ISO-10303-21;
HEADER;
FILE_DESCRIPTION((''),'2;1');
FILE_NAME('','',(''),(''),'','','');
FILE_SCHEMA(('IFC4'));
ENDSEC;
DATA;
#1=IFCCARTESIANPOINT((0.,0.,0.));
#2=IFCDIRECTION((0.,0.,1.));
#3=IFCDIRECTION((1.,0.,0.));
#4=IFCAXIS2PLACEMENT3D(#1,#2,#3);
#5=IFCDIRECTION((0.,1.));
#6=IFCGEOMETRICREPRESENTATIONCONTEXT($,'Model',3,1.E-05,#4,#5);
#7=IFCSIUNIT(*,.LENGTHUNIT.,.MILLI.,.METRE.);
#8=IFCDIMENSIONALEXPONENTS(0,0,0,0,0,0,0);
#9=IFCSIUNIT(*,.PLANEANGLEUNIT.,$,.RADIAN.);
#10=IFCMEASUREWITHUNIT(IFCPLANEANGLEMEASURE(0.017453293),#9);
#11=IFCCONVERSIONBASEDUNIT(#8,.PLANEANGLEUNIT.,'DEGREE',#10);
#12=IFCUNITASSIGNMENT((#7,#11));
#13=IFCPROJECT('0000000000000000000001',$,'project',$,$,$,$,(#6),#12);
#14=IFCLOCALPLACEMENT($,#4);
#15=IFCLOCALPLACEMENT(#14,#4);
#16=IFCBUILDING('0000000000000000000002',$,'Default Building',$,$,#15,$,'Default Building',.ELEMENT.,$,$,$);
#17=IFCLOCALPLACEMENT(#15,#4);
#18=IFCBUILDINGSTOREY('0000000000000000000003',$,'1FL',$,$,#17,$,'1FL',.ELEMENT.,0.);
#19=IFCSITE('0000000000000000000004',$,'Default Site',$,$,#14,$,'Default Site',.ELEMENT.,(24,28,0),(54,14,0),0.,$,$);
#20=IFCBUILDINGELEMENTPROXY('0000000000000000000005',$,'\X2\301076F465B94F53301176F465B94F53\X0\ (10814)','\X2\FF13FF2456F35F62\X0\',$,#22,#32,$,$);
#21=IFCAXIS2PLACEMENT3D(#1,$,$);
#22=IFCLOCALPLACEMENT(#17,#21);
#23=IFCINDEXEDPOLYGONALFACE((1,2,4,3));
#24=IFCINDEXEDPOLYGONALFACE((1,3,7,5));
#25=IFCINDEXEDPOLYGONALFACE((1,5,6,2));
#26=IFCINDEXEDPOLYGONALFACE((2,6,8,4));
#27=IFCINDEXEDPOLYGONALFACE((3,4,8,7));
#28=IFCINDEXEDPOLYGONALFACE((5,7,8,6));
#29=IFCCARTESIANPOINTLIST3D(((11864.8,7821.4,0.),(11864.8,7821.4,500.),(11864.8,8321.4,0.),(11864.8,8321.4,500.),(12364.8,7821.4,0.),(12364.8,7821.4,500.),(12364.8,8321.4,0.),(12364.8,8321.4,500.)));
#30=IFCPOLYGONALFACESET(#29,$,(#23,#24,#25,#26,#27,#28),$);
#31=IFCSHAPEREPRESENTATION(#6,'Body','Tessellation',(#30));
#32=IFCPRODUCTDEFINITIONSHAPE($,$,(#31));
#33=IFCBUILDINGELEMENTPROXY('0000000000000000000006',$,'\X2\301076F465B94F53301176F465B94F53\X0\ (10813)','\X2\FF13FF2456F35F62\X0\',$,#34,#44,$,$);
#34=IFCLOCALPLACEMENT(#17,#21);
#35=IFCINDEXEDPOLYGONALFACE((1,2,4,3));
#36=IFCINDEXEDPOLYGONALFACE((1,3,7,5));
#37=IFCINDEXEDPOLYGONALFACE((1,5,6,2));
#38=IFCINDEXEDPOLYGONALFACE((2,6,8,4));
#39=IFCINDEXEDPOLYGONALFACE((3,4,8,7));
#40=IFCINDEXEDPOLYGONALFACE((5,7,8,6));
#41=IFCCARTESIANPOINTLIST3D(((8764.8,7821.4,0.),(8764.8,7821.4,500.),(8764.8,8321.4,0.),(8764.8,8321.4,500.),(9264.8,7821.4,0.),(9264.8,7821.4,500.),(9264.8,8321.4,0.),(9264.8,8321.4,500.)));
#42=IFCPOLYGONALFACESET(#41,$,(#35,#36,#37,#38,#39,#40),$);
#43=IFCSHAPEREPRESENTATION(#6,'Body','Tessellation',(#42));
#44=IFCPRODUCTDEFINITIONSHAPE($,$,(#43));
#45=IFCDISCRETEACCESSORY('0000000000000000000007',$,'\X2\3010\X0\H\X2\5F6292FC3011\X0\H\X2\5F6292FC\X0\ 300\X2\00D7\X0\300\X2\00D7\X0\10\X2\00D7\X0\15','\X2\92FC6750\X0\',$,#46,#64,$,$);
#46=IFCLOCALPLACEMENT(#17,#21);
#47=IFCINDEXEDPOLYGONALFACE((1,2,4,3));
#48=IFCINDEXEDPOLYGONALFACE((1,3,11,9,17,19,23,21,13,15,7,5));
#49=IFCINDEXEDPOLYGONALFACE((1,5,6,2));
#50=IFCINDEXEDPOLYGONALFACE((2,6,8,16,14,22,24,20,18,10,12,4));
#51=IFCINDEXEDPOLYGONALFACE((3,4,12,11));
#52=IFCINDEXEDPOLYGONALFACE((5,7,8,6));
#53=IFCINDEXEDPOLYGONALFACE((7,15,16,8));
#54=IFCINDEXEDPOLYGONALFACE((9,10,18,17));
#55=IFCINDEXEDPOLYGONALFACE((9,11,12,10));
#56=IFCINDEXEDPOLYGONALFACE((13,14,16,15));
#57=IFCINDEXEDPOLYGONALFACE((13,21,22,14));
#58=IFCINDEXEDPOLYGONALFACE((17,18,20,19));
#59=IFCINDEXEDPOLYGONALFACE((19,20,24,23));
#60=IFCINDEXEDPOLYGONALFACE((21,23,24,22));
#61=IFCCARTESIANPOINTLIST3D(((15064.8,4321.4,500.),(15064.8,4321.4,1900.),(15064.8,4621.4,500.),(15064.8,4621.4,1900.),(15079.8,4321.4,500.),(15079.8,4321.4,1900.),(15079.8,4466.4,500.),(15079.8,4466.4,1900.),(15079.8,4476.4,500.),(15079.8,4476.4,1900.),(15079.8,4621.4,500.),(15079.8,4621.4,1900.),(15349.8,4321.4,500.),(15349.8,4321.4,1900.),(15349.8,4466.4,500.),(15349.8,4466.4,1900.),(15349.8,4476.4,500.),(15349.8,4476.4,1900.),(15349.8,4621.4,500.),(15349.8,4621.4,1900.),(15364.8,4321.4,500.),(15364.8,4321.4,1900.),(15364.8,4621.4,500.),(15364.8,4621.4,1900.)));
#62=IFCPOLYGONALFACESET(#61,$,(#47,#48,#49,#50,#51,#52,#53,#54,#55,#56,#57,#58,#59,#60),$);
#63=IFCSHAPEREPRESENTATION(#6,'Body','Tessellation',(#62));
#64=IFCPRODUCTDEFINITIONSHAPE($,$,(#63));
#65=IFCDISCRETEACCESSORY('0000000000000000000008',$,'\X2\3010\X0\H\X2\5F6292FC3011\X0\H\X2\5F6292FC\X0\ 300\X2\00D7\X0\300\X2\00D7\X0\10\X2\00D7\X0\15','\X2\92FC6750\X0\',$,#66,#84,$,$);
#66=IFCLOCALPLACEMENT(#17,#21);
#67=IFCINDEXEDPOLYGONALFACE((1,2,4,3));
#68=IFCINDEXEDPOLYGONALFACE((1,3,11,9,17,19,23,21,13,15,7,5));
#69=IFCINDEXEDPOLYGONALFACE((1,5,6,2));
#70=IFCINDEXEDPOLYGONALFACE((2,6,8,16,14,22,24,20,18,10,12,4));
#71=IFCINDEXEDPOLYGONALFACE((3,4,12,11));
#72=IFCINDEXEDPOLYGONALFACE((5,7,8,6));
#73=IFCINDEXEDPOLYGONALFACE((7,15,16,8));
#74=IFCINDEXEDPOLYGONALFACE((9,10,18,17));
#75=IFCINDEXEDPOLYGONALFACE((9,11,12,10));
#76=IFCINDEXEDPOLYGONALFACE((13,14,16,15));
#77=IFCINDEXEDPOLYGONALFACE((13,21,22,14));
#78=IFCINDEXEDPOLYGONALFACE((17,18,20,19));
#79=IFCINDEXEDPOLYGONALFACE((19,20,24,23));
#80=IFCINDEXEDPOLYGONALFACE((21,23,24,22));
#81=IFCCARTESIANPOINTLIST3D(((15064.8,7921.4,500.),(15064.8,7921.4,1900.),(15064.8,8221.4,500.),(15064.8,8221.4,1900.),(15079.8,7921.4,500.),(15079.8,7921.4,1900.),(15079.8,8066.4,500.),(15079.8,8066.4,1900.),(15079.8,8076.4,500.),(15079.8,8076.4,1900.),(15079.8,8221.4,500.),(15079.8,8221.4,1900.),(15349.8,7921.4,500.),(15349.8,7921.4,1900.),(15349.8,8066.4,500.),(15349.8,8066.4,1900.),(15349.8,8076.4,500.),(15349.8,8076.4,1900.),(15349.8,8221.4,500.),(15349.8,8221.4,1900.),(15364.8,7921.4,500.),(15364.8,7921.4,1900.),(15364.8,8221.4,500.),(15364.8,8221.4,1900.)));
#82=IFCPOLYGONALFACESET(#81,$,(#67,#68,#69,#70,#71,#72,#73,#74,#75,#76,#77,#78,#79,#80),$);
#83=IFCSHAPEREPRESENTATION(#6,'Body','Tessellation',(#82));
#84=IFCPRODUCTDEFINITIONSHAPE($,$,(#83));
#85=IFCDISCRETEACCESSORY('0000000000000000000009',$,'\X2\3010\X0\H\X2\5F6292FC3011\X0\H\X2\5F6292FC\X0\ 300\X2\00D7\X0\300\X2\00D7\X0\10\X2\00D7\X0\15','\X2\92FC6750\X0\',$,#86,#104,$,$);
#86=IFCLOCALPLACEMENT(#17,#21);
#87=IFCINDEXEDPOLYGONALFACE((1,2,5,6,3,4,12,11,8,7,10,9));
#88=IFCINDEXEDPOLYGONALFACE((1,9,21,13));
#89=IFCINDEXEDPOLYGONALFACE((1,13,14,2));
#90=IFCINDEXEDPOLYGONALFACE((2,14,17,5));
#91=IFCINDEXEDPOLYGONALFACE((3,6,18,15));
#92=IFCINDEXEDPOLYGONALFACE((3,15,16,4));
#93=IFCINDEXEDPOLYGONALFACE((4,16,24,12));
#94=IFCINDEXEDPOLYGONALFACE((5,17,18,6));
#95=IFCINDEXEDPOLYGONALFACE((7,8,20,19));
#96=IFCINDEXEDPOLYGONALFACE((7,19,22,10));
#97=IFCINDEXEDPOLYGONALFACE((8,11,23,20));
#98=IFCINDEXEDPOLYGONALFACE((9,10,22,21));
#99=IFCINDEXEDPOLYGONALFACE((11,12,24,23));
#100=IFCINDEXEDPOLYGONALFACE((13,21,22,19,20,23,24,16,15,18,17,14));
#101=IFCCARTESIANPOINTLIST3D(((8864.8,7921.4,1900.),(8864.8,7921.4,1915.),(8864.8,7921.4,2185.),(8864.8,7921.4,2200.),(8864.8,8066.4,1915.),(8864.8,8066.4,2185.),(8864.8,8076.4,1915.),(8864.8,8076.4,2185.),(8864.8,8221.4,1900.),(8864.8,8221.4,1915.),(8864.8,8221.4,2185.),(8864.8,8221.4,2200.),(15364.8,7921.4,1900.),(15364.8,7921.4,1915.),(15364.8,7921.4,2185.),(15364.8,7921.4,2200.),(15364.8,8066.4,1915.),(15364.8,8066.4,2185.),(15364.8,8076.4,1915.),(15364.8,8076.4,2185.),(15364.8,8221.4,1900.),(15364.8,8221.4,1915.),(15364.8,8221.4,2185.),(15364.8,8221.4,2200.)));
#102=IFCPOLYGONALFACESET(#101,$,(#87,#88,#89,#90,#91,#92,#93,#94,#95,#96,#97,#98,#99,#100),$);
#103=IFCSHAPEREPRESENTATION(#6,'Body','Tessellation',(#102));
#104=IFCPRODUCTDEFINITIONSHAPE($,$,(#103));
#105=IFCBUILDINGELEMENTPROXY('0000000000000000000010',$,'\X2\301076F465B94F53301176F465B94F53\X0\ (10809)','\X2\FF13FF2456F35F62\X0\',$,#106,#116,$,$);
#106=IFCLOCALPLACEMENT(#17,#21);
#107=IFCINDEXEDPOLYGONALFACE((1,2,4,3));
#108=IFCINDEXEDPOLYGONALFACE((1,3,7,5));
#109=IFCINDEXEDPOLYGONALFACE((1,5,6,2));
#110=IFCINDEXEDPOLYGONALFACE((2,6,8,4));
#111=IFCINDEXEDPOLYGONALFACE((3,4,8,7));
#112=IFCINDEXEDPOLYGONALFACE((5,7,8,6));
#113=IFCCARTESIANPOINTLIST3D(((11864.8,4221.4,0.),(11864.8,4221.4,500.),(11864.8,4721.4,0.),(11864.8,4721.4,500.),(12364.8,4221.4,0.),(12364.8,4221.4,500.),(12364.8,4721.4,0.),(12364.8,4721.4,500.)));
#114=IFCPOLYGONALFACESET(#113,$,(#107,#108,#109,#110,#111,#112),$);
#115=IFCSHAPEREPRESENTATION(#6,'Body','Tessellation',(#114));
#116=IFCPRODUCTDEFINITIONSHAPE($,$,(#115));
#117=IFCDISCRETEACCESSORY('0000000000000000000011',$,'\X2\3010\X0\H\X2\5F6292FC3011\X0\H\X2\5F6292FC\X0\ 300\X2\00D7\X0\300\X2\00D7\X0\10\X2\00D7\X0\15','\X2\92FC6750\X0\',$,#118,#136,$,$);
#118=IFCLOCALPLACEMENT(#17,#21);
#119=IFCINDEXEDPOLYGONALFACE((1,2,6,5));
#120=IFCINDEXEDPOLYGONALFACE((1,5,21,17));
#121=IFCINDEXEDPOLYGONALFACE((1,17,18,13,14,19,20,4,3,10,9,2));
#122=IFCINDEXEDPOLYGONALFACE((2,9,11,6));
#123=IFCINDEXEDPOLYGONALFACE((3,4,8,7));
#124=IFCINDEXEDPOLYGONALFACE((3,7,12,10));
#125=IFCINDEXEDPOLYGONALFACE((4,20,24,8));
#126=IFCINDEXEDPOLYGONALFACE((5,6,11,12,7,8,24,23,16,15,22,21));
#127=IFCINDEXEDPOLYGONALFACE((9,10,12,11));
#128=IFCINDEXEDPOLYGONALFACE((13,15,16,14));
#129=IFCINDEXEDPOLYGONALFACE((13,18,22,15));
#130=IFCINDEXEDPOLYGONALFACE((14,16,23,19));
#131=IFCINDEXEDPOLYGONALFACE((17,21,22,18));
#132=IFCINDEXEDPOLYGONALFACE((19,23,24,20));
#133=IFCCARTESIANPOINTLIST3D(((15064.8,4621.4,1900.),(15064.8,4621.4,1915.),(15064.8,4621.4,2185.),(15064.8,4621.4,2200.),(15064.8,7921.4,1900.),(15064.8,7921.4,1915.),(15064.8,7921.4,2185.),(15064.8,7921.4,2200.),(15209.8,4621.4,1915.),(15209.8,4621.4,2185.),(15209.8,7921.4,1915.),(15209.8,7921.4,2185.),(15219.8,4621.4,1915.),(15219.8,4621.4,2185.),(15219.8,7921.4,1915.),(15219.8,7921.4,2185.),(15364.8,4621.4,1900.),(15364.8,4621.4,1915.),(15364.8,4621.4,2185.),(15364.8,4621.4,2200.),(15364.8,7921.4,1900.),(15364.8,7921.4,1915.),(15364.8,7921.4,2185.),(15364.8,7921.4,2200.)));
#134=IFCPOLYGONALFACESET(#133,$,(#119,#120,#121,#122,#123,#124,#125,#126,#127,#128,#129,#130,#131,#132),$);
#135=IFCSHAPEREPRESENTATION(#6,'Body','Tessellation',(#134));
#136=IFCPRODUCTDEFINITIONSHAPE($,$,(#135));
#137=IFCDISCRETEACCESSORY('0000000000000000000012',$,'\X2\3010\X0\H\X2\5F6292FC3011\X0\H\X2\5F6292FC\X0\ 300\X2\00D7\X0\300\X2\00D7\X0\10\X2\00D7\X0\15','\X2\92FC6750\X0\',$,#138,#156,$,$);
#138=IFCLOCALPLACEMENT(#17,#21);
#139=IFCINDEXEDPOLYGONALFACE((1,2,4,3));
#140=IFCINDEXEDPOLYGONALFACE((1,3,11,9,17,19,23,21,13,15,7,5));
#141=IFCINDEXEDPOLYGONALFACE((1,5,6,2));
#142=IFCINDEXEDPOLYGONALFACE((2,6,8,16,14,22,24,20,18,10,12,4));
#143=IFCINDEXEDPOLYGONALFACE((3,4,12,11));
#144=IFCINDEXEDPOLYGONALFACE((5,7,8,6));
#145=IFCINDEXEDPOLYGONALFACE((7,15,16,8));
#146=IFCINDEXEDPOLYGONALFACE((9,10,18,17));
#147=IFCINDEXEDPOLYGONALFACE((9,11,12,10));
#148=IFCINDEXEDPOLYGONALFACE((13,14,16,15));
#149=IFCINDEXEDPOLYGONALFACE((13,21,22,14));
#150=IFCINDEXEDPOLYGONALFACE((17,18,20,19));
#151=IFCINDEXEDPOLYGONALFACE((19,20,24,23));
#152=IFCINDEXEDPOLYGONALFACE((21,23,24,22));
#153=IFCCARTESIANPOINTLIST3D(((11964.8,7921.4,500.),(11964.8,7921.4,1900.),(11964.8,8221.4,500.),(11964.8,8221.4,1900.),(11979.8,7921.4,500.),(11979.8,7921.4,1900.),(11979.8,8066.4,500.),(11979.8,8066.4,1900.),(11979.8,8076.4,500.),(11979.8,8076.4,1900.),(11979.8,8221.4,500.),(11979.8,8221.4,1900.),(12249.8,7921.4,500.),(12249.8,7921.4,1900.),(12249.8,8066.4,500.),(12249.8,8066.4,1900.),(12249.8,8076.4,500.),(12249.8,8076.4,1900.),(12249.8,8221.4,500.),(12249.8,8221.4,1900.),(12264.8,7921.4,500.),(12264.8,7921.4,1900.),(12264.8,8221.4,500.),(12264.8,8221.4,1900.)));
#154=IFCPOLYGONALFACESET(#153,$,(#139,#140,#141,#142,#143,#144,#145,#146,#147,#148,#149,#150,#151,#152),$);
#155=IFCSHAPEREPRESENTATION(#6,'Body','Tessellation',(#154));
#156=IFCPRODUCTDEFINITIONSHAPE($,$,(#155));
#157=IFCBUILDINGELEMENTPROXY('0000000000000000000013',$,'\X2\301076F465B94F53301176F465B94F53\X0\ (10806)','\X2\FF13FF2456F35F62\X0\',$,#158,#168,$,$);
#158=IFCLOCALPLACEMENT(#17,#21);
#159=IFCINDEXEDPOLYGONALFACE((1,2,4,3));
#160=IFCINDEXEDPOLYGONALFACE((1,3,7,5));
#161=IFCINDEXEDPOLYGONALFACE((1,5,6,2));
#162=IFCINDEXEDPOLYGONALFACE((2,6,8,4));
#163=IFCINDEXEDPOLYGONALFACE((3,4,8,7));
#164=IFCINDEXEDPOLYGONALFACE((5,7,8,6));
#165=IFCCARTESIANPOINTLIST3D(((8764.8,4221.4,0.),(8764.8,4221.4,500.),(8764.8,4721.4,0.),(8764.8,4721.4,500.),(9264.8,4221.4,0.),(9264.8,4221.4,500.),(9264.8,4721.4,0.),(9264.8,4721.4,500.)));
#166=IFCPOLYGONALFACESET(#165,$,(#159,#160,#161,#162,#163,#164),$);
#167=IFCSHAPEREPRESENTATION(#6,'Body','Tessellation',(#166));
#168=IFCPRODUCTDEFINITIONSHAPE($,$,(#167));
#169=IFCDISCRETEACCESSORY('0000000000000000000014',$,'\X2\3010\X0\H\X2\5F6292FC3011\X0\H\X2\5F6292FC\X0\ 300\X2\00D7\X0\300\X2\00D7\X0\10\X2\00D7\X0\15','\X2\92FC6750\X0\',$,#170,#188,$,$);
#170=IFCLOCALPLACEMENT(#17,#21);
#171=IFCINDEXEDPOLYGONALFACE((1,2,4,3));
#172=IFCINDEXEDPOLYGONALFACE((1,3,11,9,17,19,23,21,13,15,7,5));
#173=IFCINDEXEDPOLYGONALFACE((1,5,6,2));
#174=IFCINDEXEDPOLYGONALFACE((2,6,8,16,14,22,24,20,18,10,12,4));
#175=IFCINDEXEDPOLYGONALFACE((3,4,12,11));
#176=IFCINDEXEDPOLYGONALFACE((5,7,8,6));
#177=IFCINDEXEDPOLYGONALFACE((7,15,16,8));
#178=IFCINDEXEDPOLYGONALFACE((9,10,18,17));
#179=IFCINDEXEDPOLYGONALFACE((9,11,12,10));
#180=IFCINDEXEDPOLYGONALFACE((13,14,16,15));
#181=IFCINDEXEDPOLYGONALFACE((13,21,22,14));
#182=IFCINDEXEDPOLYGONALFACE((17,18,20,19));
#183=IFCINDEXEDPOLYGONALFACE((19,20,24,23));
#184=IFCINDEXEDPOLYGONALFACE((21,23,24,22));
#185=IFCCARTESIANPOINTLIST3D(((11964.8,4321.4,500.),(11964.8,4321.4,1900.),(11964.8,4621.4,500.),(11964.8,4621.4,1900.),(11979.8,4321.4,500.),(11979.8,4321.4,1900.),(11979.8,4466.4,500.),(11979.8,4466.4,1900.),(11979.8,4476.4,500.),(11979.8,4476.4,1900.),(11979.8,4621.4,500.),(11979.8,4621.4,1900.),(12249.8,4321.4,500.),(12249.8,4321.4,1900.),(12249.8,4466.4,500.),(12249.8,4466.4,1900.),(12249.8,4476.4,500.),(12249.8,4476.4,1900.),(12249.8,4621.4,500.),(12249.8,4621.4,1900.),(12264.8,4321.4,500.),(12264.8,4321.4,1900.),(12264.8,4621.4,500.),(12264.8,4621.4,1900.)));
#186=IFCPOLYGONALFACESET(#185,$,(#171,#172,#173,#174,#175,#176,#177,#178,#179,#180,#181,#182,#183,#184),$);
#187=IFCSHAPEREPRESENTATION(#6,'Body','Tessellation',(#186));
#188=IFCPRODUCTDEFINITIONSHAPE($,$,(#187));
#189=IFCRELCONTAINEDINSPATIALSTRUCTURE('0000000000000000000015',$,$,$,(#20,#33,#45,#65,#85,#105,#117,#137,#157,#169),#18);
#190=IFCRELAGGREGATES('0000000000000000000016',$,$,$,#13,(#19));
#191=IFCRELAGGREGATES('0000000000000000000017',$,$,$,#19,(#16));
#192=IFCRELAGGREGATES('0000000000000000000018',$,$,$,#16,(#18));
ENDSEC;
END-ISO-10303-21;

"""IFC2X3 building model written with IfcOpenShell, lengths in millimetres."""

from ifc_helpers import new_model, entity, si_unit, converted_unit, direction, frame, origin_with_axes, origin_2d_with_axis, place, context, project, spatial, rectangle, i_section, extrude, source, transform, mapped, element, save


model = new_model("IFC2X3")

# Units and contexts
model_context = context("Model", 3, precision=1e-05, world=origin_with_axes(), true_north=direction((0.0, 1.0)))
ifc_project = project(units=[si_unit("LENGTHUNIT", "METRE", prefix="MILLI"), converted_unit("PLANEANGLEUNIT", "DEGREE", entity("IfcPlaneAngleMeasure", 0.017453293), si_unit("PLANEANGLEUNIT", "RADIAN"), dimensions=[0, 0, 0, 0, 0, 0, 0])], contexts=[model_context])

# Site, building, storey
site_placement = place(None, origin_with_axes())
site = spatial("IfcSite", under=ifc_project, at=site_placement, Name="Default Site", LongName="Default Site", CompositionType="ELEMENT", RefLatitude=(24, 28, 0), RefLongitude=(54, 14, 0), RefElevation=0.0)
building_placement = place(site_placement, origin_with_axes())
building = spatial("IfcBuilding", under=site, at=building_placement, Name="Default Building", LongName="Default Building", CompositionType="ELEMENT")
storey_placement = place(building_placement, origin_with_axes())
storey = spatial("IfcBuildingStorey", under=building, at=storey_placement, Name="1FL", LongName="1FL", CompositionType="ELEMENT", Elevation=0.0)

# Building element proxies
shared_shape_1 = source(origin_with_axes(), model_context, "Body", "SweptSolid", [
    extrude(rectangle(XDim=500.0, YDim=500.0, at=origin_2d_with_axis()), origin_with_axes(), (0.0, 0.0, 1.0), 500.0),
])
proxy_1_placement = place(storey_placement, frame((12114.8, 8071.4, 0.0), z_axis=(0.0, 0.0, 1.0), x_axis=(1.0, 0.0, 0.0)))
element("IfcBuildingElementProxy", 1, at=proxy_1_placement, inside=storey, Name="【直方体】直方体 (10814)", Description="３Ｄ図形", context=model_context, shape_type="MappedRepresentation", body=[
    mapped(shared_shape_1, transform((0.0, 0.0, 0.0))),
])
shared_shape_2 = source(origin_with_axes(), model_context, "Body", "SweptSolid", [
    extrude(rectangle(XDim=500.0, YDim=500.0, at=origin_2d_with_axis()), origin_with_axes(), (0.0, 0.0, 1.0), 500.0),
])
proxy_2_placement = place(storey_placement, frame((9014.8, 8071.4, 0.0), z_axis=(0.0, 0.0, 1.0), x_axis=(1.0, 0.0, 0.0)))
element("IfcBuildingElementProxy", 2, at=proxy_2_placement, inside=storey, Name="【直方体】直方体 (10813)", Description="３Ｄ図形", context=model_context, shape_type="MappedRepresentation", body=[
    mapped(shared_shape_2, transform((0.0, 0.0, 0.0))),
])

# Discrete accessories
shared_shape_3 = source(origin_with_axes(), model_context, "Body", "SweptSolid", [
    extrude(i_section(OverallWidth=300.0, OverallDepth=300.0, WebThickness=10.0, FlangeThickness=15.0, at=origin_2d_with_axis()), frame((700.0, 0.0, -150.0), z_axis=(-1.0, 0.0, 0.0), x_axis=(0.0, -1.0, 0.0)), (0.0, 0.0, 1.0), 1400.0),
])
discrete_accessory_1_placement = place(storey_placement, frame((15064.8, 4471.4, 1200.0), z_axis=(-1.0, 0.0, 0.0), x_axis=(0.0, 0.0, 1.0)))
element("IfcDiscreteAccessory", 3, at=discrete_accessory_1_placement, inside=storey, Name="【H形鋼】H形鋼 300×300×10×15", Description="鋼材", context=model_context, shape_type="MappedRepresentation", body=[
    mapped(shared_shape_3, transform((0.0, 0.0, 0.0))),
])
shared_shape_4 = source(origin_with_axes(), model_context, "Body", "SweptSolid", [
    extrude(i_section(OverallWidth=300.0, OverallDepth=300.0, WebThickness=10.0, FlangeThickness=15.0, at=origin_2d_with_axis()), frame((700.0, 0.0, -150.0), z_axis=(-1.0, 0.0, 0.0), x_axis=(0.0, -1.0, 0.0)), (0.0, 0.0, 1.0), 1400.0),
])
discrete_accessory_2_placement = place(storey_placement, frame((15064.8, 8071.4, 1200.0), z_axis=(-1.0, 0.0, 0.0), x_axis=(0.0, 0.0, 1.0)))
element("IfcDiscreteAccessory", 4, at=discrete_accessory_2_placement, inside=storey, Name="【H形鋼】H形鋼 300×300×10×15", Description="鋼材", context=model_context, shape_type="MappedRepresentation", body=[
    mapped(shared_shape_4, transform((0.0, 0.0, 0.0))),
])
shared_shape_5 = source(origin_with_axes(), model_context, "Body", "SweptSolid", [
    extrude(i_section(OverallWidth=300.0, OverallDepth=300.0, WebThickness=10.0, FlangeThickness=15.0, at=origin_2d_with_axis()), frame((3250.0, 0.0, -150.0), z_axis=(-1.0, 0.0, 0.0), x_axis=(0.0, -1.0, 0.0)), (0.0, 0.0, 1.0), 6500.0),
])
discrete_accessory_3_placement = place(storey_placement, frame((12114.8, 8071.4, 2200.0), z_axis=(0.0, 0.0, 1.0), x_axis=(-1.0, 0.0, 0.0)))
element("IfcDiscreteAccessory", 5, at=discrete_accessory_3_placement, inside=storey, Name="【H形鋼】H形鋼 300×300×10×15", Description="鋼材", context=model_context, shape_type="MappedRepresentation", body=[
    mapped(shared_shape_5, transform((0.0, 0.0, 0.0))),
])

# Building element proxy
shared_shape_6 = source(origin_with_axes(), model_context, "Body", "SweptSolid", [
    extrude(rectangle(XDim=500.0, YDim=500.0, at=origin_2d_with_axis()), origin_with_axes(), (0.0, 0.0, 1.0), 500.0),
])
proxy_3_placement = place(storey_placement, frame((12114.8, 4471.4, 0.0), z_axis=(0.0, 0.0, 1.0), x_axis=(1.0, 0.0, 0.0)))
element("IfcBuildingElementProxy", 6, at=proxy_3_placement, inside=storey, Name="【直方体】直方体 (10809)", Description="３Ｄ図形", context=model_context, shape_type="MappedRepresentation", body=[
    mapped(shared_shape_6, transform((0.0, 0.0, 0.0))),
])

# Discrete accessories
shared_shape_7 = source(origin_with_axes(), model_context, "Body", "SweptSolid", [
    extrude(i_section(OverallWidth=300.0, OverallDepth=300.0, WebThickness=10.0, FlangeThickness=15.0, at=origin_2d_with_axis()), frame((1650.0, 0.0, -150.0), z_axis=(-1.0, 0.0, 0.0), x_axis=(0.0, -1.0, 0.0)), (0.0, 0.0, 1.0), 3300.0),
])
discrete_accessory_4_placement = place(storey_placement, frame((15214.8, 6271.4, 2200.0), z_axis=(0.0, 0.0, 1.0), x_axis=(0.0, 1.0, 0.0)))
element("IfcDiscreteAccessory", 7, at=discrete_accessory_4_placement, inside=storey, Name="【H形鋼】H形鋼 300×300×10×15", Description="鋼材", context=model_context, shape_type="MappedRepresentation", body=[
    mapped(shared_shape_7, transform((0.0, 0.0, 0.0))),
])
shared_shape_8 = source(origin_with_axes(), model_context, "Body", "SweptSolid", [
    extrude(i_section(OverallWidth=300.0, OverallDepth=300.0, WebThickness=10.0, FlangeThickness=15.0, at=origin_2d_with_axis()), frame((700.0, 0.0, -150.0), z_axis=(-1.0, 0.0, 0.0), x_axis=(0.0, -1.0, 0.0)), (0.0, 0.0, 1.0), 1400.0),
])
discrete_accessory_5_placement = place(storey_placement, frame((11964.8, 8071.4, 1200.0), z_axis=(-1.0, 0.0, 0.0), x_axis=(0.0, 0.0, 1.0)))
element("IfcDiscreteAccessory", 8, at=discrete_accessory_5_placement, inside=storey, Name="【H形鋼】H形鋼 300×300×10×15", Description="鋼材", context=model_context, shape_type="MappedRepresentation", body=[
    mapped(shared_shape_8, transform((0.0, 0.0, 0.0))),
])

# Building element proxy
shared_shape_9 = source(origin_with_axes(), model_context, "Body", "SweptSolid", [
    extrude(rectangle(XDim=500.0, YDim=500.0, at=origin_2d_with_axis()), origin_with_axes(), (0.0, 0.0, 1.0), 500.0),
])
proxy_4_placement = place(storey_placement, frame((9014.8, 4471.4, 0.0), z_axis=(0.0, 0.0, 1.0), x_axis=(1.0, 0.0, 0.0)))
element("IfcBuildingElementProxy", 9, at=proxy_4_placement, inside=storey, Name="【直方体】直方体 (10806)", Description="３Ｄ図形", context=model_context, shape_type="MappedRepresentation", body=[
    mapped(shared_shape_9, transform((0.0, 0.0, 0.0))),
])

# Discrete accessory
shared_shape_10 = source(origin_with_axes(), model_context, "Body", "SweptSolid", [
    extrude(i_section(OverallWidth=300.0, OverallDepth=300.0, WebThickness=10.0, FlangeThickness=15.0, at=origin_2d_with_axis()), frame((700.0, 0.0, -150.0), z_axis=(-1.0, 0.0, 0.0), x_axis=(0.0, -1.0, 0.0)), (0.0, 0.0, 1.0), 1400.0),
])
discrete_accessory_6_placement = place(storey_placement, frame((11964.8, 4471.4, 1200.0), z_axis=(-1.0, 0.0, 0.0), x_axis=(0.0, 0.0, 1.0)))
element("IfcDiscreteAccessory", 10, at=discrete_accessory_6_placement, inside=storey, Name="【H形鋼】H形鋼 300×300×10×15", Description="鋼材", context=model_context, shape_type="MappedRepresentation", body=[
    mapped(shared_shape_10, transform((0.0, 0.0, 0.0))),
])

save(model, "model.ifc")
